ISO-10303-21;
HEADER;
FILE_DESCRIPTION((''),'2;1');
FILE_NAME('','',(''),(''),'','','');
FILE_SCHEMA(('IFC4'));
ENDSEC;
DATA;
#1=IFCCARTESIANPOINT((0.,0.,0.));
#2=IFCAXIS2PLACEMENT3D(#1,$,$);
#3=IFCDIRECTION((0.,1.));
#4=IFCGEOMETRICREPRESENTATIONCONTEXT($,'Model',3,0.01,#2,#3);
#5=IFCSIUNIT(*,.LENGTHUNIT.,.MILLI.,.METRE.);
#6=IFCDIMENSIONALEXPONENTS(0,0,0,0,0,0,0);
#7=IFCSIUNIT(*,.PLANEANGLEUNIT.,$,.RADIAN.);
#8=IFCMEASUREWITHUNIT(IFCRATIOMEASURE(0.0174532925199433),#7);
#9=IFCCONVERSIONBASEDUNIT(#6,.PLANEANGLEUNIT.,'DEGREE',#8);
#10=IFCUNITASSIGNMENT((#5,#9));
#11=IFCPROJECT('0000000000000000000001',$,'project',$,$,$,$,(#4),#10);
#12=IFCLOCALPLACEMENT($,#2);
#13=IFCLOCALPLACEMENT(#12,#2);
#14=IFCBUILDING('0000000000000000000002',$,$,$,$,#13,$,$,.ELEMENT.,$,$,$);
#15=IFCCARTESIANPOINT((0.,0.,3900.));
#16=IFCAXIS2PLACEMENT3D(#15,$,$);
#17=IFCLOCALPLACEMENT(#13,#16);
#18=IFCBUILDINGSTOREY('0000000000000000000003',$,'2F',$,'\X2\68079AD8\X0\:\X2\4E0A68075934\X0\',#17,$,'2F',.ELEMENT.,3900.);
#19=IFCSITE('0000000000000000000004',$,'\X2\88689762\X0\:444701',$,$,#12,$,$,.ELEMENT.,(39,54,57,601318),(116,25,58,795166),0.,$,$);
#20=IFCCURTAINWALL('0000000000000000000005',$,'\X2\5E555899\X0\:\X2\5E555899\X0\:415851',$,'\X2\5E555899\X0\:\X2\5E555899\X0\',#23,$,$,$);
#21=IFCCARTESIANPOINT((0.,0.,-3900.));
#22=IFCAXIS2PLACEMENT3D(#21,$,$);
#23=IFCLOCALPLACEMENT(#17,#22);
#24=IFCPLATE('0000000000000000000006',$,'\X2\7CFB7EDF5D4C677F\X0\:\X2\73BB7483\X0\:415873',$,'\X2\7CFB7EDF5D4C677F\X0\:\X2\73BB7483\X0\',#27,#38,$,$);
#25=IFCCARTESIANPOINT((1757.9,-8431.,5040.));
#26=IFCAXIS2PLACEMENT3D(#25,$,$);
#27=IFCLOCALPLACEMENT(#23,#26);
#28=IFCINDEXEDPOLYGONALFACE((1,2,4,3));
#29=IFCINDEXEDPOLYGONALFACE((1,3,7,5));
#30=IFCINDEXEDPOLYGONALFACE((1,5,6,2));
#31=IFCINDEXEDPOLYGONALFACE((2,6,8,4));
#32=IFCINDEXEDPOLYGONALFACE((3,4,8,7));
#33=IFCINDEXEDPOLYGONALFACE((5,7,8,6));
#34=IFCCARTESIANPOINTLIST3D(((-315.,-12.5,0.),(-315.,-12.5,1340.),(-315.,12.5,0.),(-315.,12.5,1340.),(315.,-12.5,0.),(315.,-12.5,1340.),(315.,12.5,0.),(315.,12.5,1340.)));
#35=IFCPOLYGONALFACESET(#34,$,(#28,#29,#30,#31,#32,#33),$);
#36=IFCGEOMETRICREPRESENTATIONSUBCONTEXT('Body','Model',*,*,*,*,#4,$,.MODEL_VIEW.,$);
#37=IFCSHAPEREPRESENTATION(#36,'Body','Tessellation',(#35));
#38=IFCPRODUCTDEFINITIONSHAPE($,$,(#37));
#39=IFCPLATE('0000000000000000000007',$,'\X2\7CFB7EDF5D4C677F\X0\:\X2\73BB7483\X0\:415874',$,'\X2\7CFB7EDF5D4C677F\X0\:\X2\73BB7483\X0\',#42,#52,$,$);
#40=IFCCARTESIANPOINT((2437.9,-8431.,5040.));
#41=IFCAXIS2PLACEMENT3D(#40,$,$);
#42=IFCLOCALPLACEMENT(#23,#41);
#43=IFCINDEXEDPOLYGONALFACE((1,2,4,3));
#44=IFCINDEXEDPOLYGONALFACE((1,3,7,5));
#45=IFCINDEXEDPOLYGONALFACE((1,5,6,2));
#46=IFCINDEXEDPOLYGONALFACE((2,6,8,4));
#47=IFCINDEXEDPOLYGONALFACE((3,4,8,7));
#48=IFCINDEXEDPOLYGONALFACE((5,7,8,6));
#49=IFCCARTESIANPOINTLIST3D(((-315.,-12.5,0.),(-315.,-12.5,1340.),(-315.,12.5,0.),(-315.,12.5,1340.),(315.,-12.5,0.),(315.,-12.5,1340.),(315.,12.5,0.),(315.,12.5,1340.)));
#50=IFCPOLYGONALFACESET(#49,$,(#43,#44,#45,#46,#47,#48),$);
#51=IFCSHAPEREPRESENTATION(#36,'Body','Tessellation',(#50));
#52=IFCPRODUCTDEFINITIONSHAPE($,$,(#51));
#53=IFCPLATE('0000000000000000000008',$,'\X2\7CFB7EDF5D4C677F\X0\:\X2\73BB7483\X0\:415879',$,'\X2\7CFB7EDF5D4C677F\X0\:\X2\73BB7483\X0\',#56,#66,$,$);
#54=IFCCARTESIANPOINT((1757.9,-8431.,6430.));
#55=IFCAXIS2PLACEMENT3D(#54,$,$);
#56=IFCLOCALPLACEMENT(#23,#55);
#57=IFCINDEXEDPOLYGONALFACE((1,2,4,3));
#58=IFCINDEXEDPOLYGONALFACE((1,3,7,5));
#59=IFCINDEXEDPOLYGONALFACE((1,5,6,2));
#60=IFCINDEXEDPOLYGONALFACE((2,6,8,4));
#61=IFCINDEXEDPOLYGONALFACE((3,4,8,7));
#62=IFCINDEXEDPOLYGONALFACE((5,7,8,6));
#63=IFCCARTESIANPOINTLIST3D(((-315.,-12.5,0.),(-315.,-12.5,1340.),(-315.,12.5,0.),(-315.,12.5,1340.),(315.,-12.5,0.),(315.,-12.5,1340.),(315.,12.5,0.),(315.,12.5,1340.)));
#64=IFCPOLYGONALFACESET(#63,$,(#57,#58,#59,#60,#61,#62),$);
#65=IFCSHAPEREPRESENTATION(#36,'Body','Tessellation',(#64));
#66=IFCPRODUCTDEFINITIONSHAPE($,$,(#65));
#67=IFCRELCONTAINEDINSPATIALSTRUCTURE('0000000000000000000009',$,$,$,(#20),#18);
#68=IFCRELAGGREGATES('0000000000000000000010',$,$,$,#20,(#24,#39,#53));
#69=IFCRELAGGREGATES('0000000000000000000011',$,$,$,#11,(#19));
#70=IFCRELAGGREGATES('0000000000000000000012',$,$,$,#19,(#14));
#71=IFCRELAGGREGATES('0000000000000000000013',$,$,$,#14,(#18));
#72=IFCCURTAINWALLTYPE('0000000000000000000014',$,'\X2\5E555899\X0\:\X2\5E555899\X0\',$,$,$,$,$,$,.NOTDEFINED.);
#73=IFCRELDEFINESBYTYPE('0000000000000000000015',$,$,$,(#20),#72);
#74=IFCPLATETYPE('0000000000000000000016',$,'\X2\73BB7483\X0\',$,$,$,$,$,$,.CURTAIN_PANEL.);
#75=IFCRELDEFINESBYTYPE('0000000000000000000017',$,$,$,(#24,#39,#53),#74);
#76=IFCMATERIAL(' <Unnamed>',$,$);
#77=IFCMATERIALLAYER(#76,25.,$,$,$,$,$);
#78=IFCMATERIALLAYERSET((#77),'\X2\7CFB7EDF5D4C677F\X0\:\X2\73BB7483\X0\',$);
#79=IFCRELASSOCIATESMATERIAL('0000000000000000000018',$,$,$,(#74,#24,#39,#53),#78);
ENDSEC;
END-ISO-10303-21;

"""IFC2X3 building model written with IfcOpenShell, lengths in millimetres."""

from ifc_helpers import new_model, entity, si_unit, converted_unit, direction, frame, origin, origin_2d_with_axis, place, context, subcontext, project, spatial, rectangle, extrude, source, transform, mapped, material, layer, layer_set, layer_usage, type_object, type_shapes, element, aggregate, save


model = new_model("IFC2X3")

# Units and contexts
model_context = context("Model", 3, precision=0.01, world=origin(), true_north=direction((0.0, 1.0)))
body_context = subcontext(model_context, "Body", "Model", "MODEL_VIEW")
ifc_project = project(units=[si_unit("LENGTHUNIT", "METRE", prefix="MILLI"), converted_unit("PLANEANGLEUNIT", "DEGREE", entity("IfcRatioMeasure", 0.0174532925199433), si_unit("PLANEANGLEUNIT", "RADIAN"), dimensions=[0, 0, 0, 0, 0, 0, 0])], contexts=[model_context])

# Site, building, storey
site_placement = place(None, origin())
site = spatial("IfcSite", under=ifc_project, at=site_placement, Name="表面:444701", CompositionType="ELEMENT", RefLatitude=(39, 54, 57, 601318), RefLongitude=(116, 25, 58, 795166), RefElevation=0.0)
building_placement = place(site_placement, origin())
building = spatial("IfcBuilding", under=site, at=building_placement, CompositionType="ELEMENT")
storey_placement = place(building_placement, frame((0.0, 0.0, 3900.0)))
storey = spatial("IfcBuildingStorey", under=building, at=storey_placement, Name="2F", ObjectType="标高:上标头", LongName="2F", CompositionType="ELEMENT", Elevation=3900.0)

# Curtain wall
curtain_wall_type = type_object("IfcCurtainWallType", Name="幕墙:幕墙", PredefinedType="NOTDEFINED")
curtain_wall_1_placement = place(storey_placement, frame((0.0, 0.0, -3900.0)))
curtain_wall_1 = element("IfcCurtainWall", 1, at=curtain_wall_1_placement, inside=storey, type_object=curtain_wall_type, Name="幕墙:幕墙:415851", ObjectType="幕墙:幕墙")

# Plates
ifc_material_1 = material(Name=" <Unnamed>")
ifc_layer = layer(ifc_material_1, 25.0)
ifc_layer_set = layer_set([ifc_layer], Name="系统嵌板:玻璃")
ifc_layer_usage_1 = layer_usage(ifc_layer_set, "AXIS3", "POSITIVE", 0.0)
plate_type = type_object("IfcPlateType", Name="玻璃", PredefinedType="CURTAIN_PANEL", material=ifc_layer_set)
shared_shape_1 = source(origin(), body_context, "Body", "SweptSolid", [
    extrude(rectangle(XDim=25.0, YDim=630.0, at=origin_2d_with_axis()), frame((0.0, 0.0, 0.0), z_axis=(0.0, 0.0, 1.0), x_axis=(0.0, 1.0, 0.0)), (0.0, 0.0, 1.0), 1340.0),
])
type_shapes(plate_type, [shared_shape_1])
plate_1_placement = place(curtain_wall_1_placement, frame((1757.9, -8431.0, 5040.0)))
plate_1 = element("IfcPlate", 2, at=plate_1_placement, type_object=plate_type, material=ifc_layer_usage_1, Name="系统嵌板:玻璃:415873", ObjectType="系统嵌板:玻璃", context=body_context, shape_type="MappedRepresentation", body=[
    mapped(shared_shape_1, transform((0.0, 0.0, 0.0), scale=1.0)),
])
ifc_layer_usage_2 = layer_usage(ifc_layer_set, "AXIS3", "POSITIVE", 0.0)
plate_2_placement = place(curtain_wall_1_placement, frame((2437.9, -8431.0, 5040.0)))
plate_2 = element("IfcPlate", 3, at=plate_2_placement, type_object=plate_type, material=ifc_layer_usage_2, Name="系统嵌板:玻璃:415874", ObjectType="系统嵌板:玻璃", context=body_context, shape_type="MappedRepresentation", body=[
    mapped(shared_shape_1, transform((0.0, 0.0, 0.0), scale=1.0)),
])
ifc_layer_usage_3 = layer_usage(ifc_layer_set, "AXIS3", "POSITIVE", 0.0)
plate_3_placement = place(curtain_wall_1_placement, frame((1757.9, -8431.0, 6430.0)))
plate_3 = element("IfcPlate", 4, at=plate_3_placement, type_object=plate_type, material=ifc_layer_usage_3, Name="系统嵌板:玻璃:415879", ObjectType="系统嵌板:玻璃", context=body_context, shape_type="MappedRepresentation", body=[
    mapped(shared_shape_1, transform((0.0, 0.0, 0.0), scale=1.0)),
])
aggregate(curtain_wall_1, [plate_1, plate_2, plate_3])

save(model, "model.ifc")
